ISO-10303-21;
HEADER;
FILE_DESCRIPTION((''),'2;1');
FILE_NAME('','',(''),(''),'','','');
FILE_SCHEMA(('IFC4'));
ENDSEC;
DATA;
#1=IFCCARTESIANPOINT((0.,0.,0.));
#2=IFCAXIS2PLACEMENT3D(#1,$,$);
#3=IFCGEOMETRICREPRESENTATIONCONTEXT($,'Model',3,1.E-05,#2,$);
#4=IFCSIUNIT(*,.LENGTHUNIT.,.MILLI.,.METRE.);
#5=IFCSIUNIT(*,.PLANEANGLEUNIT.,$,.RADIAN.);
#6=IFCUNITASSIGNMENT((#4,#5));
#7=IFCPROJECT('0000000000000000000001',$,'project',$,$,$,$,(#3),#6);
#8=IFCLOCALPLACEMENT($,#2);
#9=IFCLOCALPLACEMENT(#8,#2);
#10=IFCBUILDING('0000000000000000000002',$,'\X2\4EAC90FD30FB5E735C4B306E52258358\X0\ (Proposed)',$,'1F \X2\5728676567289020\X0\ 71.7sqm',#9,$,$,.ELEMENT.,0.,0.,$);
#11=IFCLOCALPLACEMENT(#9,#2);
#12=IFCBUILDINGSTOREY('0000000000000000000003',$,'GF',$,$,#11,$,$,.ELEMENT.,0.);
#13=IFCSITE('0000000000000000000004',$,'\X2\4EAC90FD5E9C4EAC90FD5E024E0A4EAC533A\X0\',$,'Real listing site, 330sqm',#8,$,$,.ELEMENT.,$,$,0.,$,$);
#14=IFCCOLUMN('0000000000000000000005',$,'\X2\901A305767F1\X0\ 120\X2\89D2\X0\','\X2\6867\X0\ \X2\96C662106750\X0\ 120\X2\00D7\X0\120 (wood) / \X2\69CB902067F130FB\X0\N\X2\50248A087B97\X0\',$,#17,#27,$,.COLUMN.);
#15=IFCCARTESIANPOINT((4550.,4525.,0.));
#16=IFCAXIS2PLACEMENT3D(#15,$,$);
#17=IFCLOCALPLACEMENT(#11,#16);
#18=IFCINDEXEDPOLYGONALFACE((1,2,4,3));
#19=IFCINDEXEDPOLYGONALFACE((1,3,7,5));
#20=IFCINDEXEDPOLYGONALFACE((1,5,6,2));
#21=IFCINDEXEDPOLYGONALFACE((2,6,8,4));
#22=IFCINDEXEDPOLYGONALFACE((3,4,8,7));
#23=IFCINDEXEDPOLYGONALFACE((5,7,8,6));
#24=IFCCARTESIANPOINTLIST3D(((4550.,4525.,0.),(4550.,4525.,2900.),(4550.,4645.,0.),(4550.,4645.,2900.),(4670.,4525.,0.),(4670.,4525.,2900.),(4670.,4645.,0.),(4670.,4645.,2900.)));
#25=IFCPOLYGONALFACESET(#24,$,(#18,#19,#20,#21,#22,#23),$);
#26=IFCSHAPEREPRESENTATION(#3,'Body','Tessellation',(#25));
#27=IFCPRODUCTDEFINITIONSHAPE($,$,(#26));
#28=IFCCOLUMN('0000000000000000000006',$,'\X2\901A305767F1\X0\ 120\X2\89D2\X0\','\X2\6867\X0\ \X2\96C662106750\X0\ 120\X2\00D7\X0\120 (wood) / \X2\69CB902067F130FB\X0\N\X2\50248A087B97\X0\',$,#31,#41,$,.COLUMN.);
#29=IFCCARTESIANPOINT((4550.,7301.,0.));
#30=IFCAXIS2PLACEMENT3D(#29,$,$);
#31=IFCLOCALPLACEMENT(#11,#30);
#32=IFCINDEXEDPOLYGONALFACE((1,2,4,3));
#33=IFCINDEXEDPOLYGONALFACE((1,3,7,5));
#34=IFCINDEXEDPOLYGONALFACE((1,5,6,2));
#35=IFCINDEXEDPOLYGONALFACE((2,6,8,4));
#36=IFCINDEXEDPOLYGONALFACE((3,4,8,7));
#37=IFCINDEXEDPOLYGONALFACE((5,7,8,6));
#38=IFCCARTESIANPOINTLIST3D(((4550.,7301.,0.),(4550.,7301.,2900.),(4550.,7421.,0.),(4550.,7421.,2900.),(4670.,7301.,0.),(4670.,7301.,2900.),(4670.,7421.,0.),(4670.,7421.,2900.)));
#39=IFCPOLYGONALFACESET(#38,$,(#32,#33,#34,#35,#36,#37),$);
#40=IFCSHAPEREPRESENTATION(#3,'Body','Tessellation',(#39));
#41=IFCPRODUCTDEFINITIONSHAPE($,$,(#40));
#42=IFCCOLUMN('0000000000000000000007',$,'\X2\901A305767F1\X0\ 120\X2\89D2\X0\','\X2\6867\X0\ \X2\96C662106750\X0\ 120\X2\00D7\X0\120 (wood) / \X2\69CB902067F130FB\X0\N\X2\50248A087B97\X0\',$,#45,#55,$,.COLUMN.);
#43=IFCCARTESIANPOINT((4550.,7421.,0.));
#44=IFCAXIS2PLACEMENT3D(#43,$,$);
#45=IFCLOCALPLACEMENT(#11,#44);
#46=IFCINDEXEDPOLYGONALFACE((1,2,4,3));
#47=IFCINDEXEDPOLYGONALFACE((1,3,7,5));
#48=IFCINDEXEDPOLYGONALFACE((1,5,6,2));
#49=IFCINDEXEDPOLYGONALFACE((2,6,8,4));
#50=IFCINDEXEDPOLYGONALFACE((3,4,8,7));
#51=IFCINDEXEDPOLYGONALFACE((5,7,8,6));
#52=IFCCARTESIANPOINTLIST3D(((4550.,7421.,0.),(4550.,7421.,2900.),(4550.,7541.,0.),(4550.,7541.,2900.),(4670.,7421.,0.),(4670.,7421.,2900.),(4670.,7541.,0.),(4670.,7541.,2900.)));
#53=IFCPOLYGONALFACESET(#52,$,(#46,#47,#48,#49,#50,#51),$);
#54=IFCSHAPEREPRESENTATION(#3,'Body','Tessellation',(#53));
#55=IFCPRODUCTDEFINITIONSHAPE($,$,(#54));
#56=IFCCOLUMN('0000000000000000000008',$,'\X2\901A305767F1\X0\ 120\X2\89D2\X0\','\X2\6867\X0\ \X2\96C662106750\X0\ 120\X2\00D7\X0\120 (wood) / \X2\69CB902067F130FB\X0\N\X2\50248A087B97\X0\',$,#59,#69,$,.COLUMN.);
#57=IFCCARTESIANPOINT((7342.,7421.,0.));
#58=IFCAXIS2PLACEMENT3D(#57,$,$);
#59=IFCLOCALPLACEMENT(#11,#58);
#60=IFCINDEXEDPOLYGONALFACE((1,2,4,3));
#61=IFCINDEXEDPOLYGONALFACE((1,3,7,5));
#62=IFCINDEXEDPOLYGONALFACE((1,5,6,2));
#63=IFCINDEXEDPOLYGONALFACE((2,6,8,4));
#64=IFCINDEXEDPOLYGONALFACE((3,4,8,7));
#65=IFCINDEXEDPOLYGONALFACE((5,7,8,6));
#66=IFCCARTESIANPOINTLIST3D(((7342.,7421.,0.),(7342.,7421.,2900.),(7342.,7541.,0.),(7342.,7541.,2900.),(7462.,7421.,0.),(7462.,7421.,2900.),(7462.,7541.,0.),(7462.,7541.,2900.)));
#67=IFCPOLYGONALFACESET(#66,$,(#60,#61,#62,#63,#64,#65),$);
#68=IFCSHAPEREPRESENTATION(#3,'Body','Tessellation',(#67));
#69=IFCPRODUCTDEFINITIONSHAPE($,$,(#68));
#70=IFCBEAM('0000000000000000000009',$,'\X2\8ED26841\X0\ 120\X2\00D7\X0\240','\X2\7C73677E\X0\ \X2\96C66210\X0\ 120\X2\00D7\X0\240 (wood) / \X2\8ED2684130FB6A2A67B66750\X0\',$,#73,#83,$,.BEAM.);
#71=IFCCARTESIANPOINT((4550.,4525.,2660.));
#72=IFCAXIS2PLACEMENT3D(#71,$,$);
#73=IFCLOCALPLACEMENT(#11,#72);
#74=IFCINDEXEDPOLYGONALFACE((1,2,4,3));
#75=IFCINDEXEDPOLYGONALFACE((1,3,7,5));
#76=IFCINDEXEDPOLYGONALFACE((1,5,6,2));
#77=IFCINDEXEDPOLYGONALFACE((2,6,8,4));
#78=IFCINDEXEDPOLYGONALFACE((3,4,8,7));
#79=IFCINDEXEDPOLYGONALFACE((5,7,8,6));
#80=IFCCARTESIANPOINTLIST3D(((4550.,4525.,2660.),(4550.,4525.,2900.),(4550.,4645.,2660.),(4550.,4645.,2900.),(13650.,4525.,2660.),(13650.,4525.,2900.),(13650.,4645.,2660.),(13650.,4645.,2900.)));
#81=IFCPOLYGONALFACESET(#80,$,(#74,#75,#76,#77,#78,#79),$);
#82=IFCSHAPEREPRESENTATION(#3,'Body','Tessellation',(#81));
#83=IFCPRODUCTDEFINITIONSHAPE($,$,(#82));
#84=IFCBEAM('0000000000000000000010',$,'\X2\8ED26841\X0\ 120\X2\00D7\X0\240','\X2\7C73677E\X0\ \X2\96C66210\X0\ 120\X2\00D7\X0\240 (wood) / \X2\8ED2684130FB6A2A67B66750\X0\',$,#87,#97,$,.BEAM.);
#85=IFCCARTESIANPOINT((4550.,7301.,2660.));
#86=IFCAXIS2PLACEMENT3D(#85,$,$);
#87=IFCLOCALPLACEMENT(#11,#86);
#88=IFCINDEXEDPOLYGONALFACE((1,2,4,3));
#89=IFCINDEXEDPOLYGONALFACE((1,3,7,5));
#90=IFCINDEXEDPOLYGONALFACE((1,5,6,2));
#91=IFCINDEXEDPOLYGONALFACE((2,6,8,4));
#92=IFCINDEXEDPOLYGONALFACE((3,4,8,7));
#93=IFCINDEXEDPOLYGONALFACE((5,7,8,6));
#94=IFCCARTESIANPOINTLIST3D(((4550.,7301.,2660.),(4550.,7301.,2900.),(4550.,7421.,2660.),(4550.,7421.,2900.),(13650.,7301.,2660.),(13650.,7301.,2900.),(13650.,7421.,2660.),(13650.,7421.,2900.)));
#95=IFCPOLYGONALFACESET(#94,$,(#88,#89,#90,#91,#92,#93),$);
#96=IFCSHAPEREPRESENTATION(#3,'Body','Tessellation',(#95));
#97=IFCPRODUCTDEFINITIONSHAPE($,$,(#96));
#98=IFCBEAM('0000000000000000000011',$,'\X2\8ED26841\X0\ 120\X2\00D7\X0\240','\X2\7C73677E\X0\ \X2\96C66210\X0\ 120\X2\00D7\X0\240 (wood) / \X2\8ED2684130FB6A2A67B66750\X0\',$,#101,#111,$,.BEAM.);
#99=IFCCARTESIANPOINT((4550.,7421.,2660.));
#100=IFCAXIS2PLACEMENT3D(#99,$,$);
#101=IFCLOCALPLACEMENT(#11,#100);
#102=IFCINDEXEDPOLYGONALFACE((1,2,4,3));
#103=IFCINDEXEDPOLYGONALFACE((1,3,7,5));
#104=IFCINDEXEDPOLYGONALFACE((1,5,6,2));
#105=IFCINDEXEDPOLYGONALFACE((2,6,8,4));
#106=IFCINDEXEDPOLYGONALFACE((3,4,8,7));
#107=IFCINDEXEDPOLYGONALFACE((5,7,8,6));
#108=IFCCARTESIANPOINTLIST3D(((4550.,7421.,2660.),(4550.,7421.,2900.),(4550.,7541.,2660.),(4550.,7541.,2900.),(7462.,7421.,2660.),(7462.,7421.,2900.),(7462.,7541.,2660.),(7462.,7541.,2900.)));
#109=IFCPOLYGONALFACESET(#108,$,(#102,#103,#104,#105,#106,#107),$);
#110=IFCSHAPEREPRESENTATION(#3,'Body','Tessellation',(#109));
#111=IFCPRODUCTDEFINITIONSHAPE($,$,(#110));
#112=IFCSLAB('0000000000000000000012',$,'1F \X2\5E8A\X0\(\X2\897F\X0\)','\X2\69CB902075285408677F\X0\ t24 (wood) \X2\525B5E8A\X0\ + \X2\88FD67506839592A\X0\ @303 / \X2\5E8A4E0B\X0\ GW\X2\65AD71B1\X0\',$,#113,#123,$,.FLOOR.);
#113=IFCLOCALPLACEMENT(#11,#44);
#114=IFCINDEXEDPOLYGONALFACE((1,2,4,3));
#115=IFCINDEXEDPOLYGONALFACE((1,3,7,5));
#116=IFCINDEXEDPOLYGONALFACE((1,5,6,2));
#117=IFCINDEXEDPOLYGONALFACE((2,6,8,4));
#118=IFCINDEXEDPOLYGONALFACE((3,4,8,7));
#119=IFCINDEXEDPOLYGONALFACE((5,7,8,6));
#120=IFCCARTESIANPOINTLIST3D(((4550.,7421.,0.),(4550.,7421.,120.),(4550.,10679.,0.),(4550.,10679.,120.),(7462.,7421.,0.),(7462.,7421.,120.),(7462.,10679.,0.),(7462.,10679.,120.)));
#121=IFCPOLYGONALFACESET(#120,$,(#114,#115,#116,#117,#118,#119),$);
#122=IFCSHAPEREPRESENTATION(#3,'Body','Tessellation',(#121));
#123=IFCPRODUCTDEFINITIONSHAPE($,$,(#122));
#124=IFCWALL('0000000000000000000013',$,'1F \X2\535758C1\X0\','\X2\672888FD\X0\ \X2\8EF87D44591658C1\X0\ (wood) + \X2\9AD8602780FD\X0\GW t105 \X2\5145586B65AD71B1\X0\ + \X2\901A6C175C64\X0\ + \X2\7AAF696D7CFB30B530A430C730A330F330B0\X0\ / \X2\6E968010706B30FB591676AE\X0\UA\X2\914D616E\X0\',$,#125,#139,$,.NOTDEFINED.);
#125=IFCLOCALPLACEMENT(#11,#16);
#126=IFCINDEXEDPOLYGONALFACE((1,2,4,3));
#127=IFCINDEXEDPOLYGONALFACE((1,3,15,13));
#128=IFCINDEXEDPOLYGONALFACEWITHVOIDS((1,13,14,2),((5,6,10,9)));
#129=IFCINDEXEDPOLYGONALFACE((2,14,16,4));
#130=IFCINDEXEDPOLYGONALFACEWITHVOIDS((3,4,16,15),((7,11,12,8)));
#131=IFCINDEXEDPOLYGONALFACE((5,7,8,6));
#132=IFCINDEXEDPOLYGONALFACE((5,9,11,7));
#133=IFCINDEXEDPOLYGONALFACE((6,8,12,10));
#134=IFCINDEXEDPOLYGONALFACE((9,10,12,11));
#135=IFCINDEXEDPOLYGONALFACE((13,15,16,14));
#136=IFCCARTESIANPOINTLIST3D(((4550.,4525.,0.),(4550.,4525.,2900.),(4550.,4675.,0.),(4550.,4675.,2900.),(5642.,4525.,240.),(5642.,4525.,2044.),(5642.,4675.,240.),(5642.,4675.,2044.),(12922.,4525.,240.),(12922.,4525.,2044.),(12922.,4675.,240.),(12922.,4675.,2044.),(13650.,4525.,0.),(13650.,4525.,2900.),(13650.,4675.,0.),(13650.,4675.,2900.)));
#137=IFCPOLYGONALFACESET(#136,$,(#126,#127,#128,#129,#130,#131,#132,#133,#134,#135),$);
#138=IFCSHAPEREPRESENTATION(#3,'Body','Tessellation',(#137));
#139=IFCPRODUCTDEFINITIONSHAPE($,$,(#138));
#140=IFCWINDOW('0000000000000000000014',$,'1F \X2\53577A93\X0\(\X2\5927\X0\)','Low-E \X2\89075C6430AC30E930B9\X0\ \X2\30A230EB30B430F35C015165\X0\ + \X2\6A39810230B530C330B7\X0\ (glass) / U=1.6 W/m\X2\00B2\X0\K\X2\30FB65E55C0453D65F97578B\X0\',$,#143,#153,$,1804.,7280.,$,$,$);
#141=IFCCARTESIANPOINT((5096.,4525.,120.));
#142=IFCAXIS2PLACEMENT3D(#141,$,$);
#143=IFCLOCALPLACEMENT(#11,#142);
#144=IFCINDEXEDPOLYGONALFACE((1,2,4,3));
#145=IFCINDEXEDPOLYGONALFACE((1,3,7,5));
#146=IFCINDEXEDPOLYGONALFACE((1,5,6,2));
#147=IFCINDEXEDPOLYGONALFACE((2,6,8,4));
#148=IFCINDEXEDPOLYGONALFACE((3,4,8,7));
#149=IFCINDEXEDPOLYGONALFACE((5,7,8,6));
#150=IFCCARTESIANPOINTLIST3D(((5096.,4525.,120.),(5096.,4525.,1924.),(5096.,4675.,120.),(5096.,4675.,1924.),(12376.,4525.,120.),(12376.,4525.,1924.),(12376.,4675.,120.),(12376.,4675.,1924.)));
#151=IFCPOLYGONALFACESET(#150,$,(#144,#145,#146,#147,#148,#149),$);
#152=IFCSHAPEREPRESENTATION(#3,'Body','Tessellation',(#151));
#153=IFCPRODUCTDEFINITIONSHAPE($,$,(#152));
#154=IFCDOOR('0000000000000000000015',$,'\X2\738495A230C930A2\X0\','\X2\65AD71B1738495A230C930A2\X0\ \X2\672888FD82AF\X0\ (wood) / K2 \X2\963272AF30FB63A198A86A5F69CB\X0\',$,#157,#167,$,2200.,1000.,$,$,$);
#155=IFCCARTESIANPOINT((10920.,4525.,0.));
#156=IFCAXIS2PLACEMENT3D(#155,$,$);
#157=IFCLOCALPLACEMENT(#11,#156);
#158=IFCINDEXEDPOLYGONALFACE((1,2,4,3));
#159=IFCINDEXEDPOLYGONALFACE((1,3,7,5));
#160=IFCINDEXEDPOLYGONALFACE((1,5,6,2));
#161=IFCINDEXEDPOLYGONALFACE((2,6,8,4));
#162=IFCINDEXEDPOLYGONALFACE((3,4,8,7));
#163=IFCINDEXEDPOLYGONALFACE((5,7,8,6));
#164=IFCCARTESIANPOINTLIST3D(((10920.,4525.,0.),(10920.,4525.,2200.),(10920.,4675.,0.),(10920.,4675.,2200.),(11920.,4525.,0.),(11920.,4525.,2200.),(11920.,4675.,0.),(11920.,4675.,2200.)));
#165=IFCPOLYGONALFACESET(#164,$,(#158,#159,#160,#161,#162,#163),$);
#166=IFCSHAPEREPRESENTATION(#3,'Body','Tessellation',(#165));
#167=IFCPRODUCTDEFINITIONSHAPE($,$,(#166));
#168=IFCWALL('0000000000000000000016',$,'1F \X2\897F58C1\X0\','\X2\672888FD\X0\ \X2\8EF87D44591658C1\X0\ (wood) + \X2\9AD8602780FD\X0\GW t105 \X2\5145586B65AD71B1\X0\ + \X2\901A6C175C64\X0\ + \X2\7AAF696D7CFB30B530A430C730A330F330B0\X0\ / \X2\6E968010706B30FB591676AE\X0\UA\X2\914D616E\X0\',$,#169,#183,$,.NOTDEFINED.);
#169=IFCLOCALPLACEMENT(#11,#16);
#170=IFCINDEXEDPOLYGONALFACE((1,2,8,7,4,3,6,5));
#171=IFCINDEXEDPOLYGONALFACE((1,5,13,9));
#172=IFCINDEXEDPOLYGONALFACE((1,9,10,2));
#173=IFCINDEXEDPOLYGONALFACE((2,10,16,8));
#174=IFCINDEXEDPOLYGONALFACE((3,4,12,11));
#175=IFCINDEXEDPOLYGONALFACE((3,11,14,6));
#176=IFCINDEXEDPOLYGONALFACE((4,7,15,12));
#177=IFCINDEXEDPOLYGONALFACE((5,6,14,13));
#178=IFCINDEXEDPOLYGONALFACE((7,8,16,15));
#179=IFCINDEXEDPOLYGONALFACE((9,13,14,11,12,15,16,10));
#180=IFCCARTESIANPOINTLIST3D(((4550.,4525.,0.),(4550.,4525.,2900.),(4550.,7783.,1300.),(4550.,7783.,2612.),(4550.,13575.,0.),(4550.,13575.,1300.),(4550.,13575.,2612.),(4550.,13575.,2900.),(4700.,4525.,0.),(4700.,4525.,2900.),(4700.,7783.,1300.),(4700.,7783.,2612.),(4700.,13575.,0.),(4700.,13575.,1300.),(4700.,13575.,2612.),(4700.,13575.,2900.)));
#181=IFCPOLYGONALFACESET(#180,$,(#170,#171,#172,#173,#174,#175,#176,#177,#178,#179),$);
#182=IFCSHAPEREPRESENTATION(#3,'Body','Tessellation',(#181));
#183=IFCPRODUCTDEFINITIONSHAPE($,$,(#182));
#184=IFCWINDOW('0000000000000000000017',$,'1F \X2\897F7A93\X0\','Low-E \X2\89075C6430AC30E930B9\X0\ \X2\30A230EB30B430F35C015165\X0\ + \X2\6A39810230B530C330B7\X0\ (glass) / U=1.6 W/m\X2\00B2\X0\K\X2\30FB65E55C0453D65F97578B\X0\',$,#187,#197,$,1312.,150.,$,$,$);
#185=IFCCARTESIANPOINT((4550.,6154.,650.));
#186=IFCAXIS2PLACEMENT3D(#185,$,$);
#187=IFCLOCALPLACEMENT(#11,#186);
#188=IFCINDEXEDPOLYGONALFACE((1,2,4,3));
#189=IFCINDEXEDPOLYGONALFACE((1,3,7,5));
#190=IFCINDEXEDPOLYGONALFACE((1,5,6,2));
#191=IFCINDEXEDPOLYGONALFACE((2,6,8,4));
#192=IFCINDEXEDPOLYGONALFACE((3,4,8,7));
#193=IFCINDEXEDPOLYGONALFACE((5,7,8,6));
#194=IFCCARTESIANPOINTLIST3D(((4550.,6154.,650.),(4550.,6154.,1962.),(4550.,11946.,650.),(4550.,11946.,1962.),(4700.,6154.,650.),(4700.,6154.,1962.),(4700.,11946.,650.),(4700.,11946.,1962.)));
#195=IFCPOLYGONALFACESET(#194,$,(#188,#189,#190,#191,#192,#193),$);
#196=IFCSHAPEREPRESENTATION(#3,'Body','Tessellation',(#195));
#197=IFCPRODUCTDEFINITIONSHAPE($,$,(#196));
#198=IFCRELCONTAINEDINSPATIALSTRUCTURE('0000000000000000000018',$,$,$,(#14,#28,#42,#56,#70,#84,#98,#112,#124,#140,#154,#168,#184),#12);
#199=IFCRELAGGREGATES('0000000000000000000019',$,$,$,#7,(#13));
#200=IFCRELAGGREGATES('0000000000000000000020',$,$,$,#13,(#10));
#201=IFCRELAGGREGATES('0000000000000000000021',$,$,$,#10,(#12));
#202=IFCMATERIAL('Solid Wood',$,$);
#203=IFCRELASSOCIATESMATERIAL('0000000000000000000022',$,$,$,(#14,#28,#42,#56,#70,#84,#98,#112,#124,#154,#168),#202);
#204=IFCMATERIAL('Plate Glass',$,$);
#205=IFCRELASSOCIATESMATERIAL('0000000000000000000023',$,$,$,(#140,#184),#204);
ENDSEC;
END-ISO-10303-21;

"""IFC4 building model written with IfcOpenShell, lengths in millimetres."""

from ifc_helpers import new_model, si_unit, frame, frame_2d, origin, place, context, project, spatial, rectangle, extrude, material, element, fill, save


model = new_model("IFC4")

# Units and contexts
model_context = context("Model", 3, precision=1e-05, world=origin())
ifc_project = project(units=[si_unit("LENGTHUNIT", "METRE", prefix="MILLI"), si_unit("PLANEANGLEUNIT", "RADIAN")], contexts=[model_context])

# Site, building, storey
site_placement = place(None, origin())
site = spatial("IfcSite", under=ifc_project, at=site_placement, Name="京都府京都市上京区", ObjectType="Real listing site, 330sqm", CompositionType="ELEMENT", RefElevation=0.0)
building_placement = place(site_placement, origin())
building = spatial("IfcBuilding", under=site, at=building_placement, Name="京都・平屋の別荘 (Proposed)", ObjectType="1F 在来木造 71.7sqm", CompositionType="ELEMENT", ElevationOfRefHeight=0.0, ElevationOfTerrain=0.0)
storey_placement = place(building_placement, origin())
storey = spatial("IfcBuildingStorey", under=building, at=storey_placement, Name="GF", CompositionType="ELEMENT", Elevation=0.0)

# Columns
ifc_material_1 = material(Name="Solid Wood")
column_1_placement = place(storey_placement, frame((4550.0, 4525.0, 0.0)))
element("IfcColumn", 1, at=column_1_placement, inside=storey, material=ifc_material_1, Name="通し柱 120角", Description="桧 集成材 120×120 (wood) / 構造柱・N値計算", PredefinedType="COLUMN", context=model_context, shape_type="SweptSolid", body=[
    extrude(rectangle(XDim=120.0, YDim=120.0, at=frame_2d((60.0, 60.0))), frame((4550.0, 4525.0, 0.0)), (0.0, 0.0, 1.0), 2900.0),
])
column_2_placement = place(storey_placement, frame((4550.0, 7301.0, 0.0)))
element("IfcColumn", 2, at=column_2_placement, inside=storey, material=ifc_material_1, Name="通し柱 120角", Description="桧 集成材 120×120 (wood) / 構造柱・N値計算", PredefinedType="COLUMN", context=model_context, shape_type="SweptSolid", body=[
    extrude(rectangle(XDim=120.0, YDim=120.0, at=frame_2d((60.0, 60.0))), frame((4550.0, 7301.0, 0.0)), (0.0, 0.0, 1.0), 2900.0),
])
column_3_placement = place(storey_placement, frame((4550.0, 7421.0, 0.0)))
element("IfcColumn", 3, at=column_3_placement, inside=storey, material=ifc_material_1, Name="通し柱 120角", Description="桧 集成材 120×120 (wood) / 構造柱・N値計算", PredefinedType="COLUMN", context=model_context, shape_type="SweptSolid", body=[
    extrude(rectangle(XDim=120.0, YDim=120.0, at=frame_2d((60.0, 60.0))), frame((4550.0, 7421.0, 0.0)), (0.0, 0.0, 1.0), 2900.0),
])
column_4_placement = place(storey_placement, frame((7342.0, 7421.0, 0.0)))
element("IfcColumn", 4, at=column_4_placement, inside=storey, material=ifc_material_1, Name="通し柱 120角", Description="桧 集成材 120×120 (wood) / 構造柱・N値計算", PredefinedType="COLUMN", context=model_context, shape_type="SweptSolid", body=[
    extrude(rectangle(XDim=120.0, YDim=120.0, at=frame_2d((60.0, 60.0))), frame((7342.0, 7421.0, 0.0)), (0.0, 0.0, 1.0), 2900.0),
])

# Beams
beam_1_placement = place(storey_placement, frame((4550.0, 4525.0, 2660.0)))
element("IfcBeam", 5, at=beam_1_placement, inside=storey, material=ifc_material_1, Name="軒桁 120×240", Description="米松 集成 120×240 (wood) / 軒桁・横架材", PredefinedType="BEAM", context=model_context, shape_type="SweptSolid", body=[
    extrude(rectangle(XDim=9100.0, YDim=120.0, at=frame_2d((4550.0, 60.0))), frame((4550.0, 4525.0, 2660.0)), (0.0, 0.0, 1.0), 240.0),
])
beam_2_placement = place(storey_placement, frame((4550.0, 7301.0, 2660.0)))
element("IfcBeam", 6, at=beam_2_placement, inside=storey, material=ifc_material_1, Name="軒桁 120×240", Description="米松 集成 120×240 (wood) / 軒桁・横架材", PredefinedType="BEAM", context=model_context, shape_type="SweptSolid", body=[
    extrude(rectangle(XDim=9100.0, YDim=120.0, at=frame_2d((4550.0, 60.0))), frame((4550.0, 7301.0, 2660.0)), (0.0, 0.0, 1.0), 240.0),
])
beam_3_placement = place(storey_placement, frame((4550.0, 7421.0, 2660.0)))
element("IfcBeam", 7, at=beam_3_placement, inside=storey, material=ifc_material_1, Name="軒桁 120×240", Description="米松 集成 120×240 (wood) / 軒桁・横架材", PredefinedType="BEAM", context=model_context, shape_type="SweptSolid", body=[
    extrude(rectangle(XDim=2912.0, YDim=120.0, at=frame_2d((1456.0, 60.0))), frame((4550.0, 7421.0, 2660.0)), (0.0, 0.0, 1.0), 240.0),
])

# Slab
slab_1_placement = place(storey_placement, frame((4550.0, 7421.0, 0.0)))
element("IfcSlab", 8, at=slab_1_placement, inside=storey, material=ifc_material_1, Name="1F 床(西)", Description="構造用合板 t24 (wood) 剛床 + 製材根太 @303 / 床下 GW断熱", PredefinedType="FLOOR", context=model_context, shape_type="SweptSolid", body=[
    extrude(rectangle(XDim=2912.0, YDim=3258.0, at=frame_2d((1456.0, 1629.0))), frame((4550.0, 7421.0, 0.0)), (0.0, 0.0, 1.0), 120.0),
])

# Wall, openings, window, door
wall_1_placement = place(storey_placement, frame((4550.0, 4525.0, 0.0)))
wall_1 = element("IfcWall", 9, at=wall_1_placement, inside=storey, material=ifc_material_1, Name="1F 南壁", Description="木製 軸組外壁 (wood) + 高性能GW t105 充填断熱 + 通気層 + 窯業系サイディング / 準耐火・外皮UA配慮", PredefinedType="NOTDEFINED", context=model_context, shape_type="SweptSolid", body=[
    extrude(rectangle(XDim=9100.0, YDim=150.0, at=frame_2d((4550.0, 75.0))), frame((4550.0, 4525.0, 0.0)), (0.0, 0.0, 1.0), 2900.0),
])
opening_1_placement = place(storey_placement, frame((5096.0, 4525.0, 120.0)))
opening_1 = element("IfcOpeningElement", 10, at=opening_1_placement, cuts=wall_1, PredefinedType="NOTDEFINED", context=model_context, shape_type="SweptSolid", body=[
    extrude(rectangle(XDim=7280.0, YDim=150.0, at=frame_2d((3640.0, 75.0))), frame((5096.0, 4525.0, 120.0)), (0.0, 0.0, 1.0), 1804.0),
])
opening_2_placement = place(storey_placement, frame((10920.0, 4525.0, 0.0)))
opening_2 = element("IfcOpeningElement", 11, at=opening_2_placement, cuts=wall_1, PredefinedType="NOTDEFINED", context=model_context, shape_type="SweptSolid", body=[
    extrude(rectangle(XDim=1000.0, YDim=150.0, at=frame_2d((500.0, 75.0))), frame((10920.0, 4525.0, 0.0)), (0.0, 0.0, 1.0), 2200.0),
])
ifc_material_2 = material(Name="Plate Glass")
window_1_placement = place(storey_placement, frame((5096.0, 4525.0, 120.0)))
window_1 = element("IfcWindow", 12, at=window_1_placement, inside=storey, material=ifc_material_2, Name="1F 南窓(大)", Description="Low-E 複層ガラス アルゴン封入 + 樹脂サッシ (glass) / U=1.6 W/m²K・日射取得型", OverallHeight=1804.0, OverallWidth=7280.0, context=model_context, shape_type="SweptSolid", body=[
    extrude(rectangle(XDim=7280.0, YDim=150.0, at=frame_2d((3640.0, 75.0))), frame((5096.0, 4525.0, 120.0)), (0.0, 0.0, 1.0), 1804.0),
])
fill(opening_1, window_1)
door_placement = place(storey_placement, frame((10920.0, 4525.0, 0.0)))
door = element("IfcDoor", 13, at=door_placement, inside=storey, material=ifc_material_1, Name="玄関ドア", Description="断熱玄関ドア 木製芯 (wood) / K2 防犯・採風機構", OverallHeight=2200.0, OverallWidth=1000.0, context=model_context, shape_type="SweptSolid", body=[
    extrude(rectangle(XDim=1000.0, YDim=150.0, at=frame_2d((500.0, 75.0))), frame((10920.0, 4525.0, 0.0)), (0.0, 0.0, 1.0), 2200.0),
])
fill(opening_2, door)

# Wall, opening, window
wall_2_placement = place(storey_placement, frame((4550.0, 4525.0, 0.0)))
wall_2 = element("IfcWall", 14, at=wall_2_placement, inside=storey, material=ifc_material_1, Name="1F 西壁", Description="木製 軸組外壁 (wood) + 高性能GW t105 充填断熱 + 通気層 + 窯業系サイディング / 準耐火・外皮UA配慮", PredefinedType="NOTDEFINED", context=model_context, shape_type="SweptSolid", body=[
    extrude(rectangle(XDim=150.0, YDim=9050.0, at=frame_2d((75.0, 4525.0))), frame((4550.0, 4525.0, 0.0)), (0.0, 0.0, 1.0), 2900.0),
])
opening_3_placement = place(storey_placement, frame((4550.0, 6154.0, 650.0)))
opening_3 = element("IfcOpeningElement", 15, at=opening_3_placement, cuts=wall_2, PredefinedType="NOTDEFINED", context=model_context, shape_type="SweptSolid", body=[
    extrude(rectangle(XDim=150.0, YDim=5792.0, at=frame_2d((75.0, 2896.0))), frame((4550.0, 6154.0, 650.0)), (0.0, 0.0, 1.0), 1312.0),
])
window_2_placement = place(storey_placement, frame((4550.0, 6154.0, 650.0)))
window_2 = element("IfcWindow", 16, at=window_2_placement, inside=storey, material=ifc_material_2, Name="1F 西窓", Description="Low-E 複層ガラス アルゴン封入 + 樹脂サッシ (glass) / U=1.6 W/m²K・日射取得型", OverallHeight=1312.0, OverallWidth=150.0, context=model_context, shape_type="SweptSolid", body=[
    extrude(rectangle(XDim=150.0, YDim=5792.0, at=frame_2d((75.0, 2896.0))), frame((4550.0, 6154.0, 650.0)), (0.0, 0.0, 1.0), 1312.0),
])
fill(opening_3, window_2)

save(model, "model.ifc")
